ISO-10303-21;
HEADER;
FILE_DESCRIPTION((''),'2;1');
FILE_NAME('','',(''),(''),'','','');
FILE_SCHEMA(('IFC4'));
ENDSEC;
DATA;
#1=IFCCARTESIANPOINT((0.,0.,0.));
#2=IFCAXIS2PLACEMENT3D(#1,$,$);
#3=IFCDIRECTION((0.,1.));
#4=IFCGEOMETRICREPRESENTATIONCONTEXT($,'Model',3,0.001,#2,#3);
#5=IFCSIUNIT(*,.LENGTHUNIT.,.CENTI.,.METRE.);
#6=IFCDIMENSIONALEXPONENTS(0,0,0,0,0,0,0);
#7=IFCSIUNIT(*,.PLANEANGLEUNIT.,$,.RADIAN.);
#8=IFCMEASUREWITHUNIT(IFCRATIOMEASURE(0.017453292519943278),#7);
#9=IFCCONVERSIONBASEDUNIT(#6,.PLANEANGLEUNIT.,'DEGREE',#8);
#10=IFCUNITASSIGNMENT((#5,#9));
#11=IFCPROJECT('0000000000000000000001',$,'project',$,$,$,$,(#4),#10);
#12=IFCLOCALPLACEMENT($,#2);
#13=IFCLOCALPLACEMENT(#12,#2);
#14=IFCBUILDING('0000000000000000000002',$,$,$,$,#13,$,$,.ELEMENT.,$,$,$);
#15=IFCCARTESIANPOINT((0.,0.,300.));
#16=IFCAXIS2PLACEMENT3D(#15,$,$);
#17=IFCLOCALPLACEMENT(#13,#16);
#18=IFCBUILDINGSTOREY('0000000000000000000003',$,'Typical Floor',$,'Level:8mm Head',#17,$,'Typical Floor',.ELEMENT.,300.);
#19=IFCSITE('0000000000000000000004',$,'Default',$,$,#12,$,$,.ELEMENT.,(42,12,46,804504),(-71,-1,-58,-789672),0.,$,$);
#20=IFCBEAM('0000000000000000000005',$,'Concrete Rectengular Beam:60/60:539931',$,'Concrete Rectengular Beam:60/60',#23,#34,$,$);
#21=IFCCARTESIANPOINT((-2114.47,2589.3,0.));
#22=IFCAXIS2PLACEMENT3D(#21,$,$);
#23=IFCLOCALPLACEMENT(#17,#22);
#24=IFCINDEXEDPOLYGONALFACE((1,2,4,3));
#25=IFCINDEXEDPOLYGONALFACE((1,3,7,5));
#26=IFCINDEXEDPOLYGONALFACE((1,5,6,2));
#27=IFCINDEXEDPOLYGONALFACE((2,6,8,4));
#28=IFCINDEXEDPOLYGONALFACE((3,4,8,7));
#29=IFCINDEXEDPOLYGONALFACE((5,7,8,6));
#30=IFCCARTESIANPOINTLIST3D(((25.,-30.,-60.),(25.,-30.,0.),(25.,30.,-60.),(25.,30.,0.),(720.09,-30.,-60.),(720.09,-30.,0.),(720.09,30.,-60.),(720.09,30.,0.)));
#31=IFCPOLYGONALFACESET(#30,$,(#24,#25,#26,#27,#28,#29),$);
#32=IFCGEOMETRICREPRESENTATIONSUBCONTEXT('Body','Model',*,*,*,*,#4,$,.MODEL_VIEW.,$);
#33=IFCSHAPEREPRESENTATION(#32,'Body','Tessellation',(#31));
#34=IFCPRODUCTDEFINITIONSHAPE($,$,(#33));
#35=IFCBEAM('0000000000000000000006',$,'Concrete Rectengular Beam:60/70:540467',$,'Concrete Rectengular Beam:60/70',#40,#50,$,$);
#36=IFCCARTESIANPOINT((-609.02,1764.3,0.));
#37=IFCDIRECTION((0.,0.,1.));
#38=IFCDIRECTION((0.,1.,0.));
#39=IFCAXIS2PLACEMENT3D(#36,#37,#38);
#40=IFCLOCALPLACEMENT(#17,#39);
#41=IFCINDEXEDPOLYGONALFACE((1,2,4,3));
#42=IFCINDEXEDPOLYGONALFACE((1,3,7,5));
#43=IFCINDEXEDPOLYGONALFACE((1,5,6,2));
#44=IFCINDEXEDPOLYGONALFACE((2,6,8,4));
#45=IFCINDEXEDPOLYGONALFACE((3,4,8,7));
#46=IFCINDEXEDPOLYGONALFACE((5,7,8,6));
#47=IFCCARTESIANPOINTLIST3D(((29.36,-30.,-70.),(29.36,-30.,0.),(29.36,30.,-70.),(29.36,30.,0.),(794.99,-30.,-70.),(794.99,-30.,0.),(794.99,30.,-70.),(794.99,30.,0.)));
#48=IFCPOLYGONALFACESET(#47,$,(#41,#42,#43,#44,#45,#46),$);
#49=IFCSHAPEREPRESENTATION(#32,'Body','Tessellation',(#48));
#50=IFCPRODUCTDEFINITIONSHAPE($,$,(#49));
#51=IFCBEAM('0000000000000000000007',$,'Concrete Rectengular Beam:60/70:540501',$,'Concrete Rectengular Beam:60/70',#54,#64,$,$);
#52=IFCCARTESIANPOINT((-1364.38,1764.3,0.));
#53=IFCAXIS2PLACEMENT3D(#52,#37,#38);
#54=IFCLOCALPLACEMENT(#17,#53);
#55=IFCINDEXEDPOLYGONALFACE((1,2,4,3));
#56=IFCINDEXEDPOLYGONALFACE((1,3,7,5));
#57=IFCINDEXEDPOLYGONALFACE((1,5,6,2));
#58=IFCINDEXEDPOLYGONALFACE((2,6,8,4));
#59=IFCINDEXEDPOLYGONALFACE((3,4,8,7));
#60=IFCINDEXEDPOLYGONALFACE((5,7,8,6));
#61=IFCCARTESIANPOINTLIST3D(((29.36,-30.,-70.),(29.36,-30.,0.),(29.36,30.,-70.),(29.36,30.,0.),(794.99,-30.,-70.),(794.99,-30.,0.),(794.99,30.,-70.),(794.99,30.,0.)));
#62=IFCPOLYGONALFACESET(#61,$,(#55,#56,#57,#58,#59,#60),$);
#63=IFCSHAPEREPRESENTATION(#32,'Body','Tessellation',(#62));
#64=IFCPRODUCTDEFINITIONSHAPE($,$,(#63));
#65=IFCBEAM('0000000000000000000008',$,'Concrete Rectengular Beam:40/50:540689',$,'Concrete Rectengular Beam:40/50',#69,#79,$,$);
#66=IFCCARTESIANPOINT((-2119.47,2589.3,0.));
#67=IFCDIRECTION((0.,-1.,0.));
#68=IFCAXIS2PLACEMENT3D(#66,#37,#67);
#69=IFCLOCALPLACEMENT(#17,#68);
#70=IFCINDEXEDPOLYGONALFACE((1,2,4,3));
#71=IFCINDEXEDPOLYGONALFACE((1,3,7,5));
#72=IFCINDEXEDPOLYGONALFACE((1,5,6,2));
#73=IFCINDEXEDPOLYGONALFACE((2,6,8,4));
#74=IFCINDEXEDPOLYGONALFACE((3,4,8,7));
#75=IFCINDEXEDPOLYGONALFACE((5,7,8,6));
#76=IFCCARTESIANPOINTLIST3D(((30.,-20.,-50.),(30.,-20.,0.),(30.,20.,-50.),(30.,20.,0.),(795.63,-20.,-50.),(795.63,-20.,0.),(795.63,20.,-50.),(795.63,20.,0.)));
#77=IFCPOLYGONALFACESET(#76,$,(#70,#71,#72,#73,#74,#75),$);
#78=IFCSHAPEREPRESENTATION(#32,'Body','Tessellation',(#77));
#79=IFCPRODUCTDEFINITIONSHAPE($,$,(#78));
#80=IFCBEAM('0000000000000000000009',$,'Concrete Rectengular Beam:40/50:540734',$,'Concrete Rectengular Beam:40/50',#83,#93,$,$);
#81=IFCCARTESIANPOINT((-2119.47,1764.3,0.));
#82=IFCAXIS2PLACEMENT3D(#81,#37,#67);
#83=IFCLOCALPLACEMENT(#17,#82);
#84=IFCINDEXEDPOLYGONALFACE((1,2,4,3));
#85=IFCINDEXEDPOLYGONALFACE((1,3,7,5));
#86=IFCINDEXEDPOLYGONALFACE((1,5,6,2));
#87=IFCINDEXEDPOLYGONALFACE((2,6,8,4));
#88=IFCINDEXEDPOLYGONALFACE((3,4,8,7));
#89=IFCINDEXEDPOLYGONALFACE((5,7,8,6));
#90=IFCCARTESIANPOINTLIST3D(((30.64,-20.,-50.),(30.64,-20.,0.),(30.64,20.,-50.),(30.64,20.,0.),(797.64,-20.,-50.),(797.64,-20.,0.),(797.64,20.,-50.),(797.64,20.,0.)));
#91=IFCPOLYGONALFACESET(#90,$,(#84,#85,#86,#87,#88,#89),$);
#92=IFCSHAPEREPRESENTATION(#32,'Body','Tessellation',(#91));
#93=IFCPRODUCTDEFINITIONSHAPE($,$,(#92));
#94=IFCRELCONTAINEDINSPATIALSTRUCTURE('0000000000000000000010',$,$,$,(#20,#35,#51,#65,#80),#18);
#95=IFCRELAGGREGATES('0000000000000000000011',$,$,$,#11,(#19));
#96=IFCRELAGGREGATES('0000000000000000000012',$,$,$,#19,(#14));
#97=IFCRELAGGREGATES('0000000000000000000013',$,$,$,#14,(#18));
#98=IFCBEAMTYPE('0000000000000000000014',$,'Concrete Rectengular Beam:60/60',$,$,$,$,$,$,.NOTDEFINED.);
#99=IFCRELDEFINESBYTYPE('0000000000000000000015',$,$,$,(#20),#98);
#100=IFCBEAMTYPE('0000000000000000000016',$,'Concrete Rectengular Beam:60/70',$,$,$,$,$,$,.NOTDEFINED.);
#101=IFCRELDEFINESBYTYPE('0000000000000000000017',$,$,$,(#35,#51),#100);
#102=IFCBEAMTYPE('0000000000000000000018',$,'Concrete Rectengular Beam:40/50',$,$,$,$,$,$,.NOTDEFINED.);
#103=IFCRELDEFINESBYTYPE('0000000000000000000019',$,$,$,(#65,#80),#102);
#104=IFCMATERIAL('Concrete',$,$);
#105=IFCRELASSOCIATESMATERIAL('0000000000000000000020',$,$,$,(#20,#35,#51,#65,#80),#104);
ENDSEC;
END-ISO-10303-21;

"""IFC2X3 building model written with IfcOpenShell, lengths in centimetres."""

from ifc_helpers import new_model, entity, si_unit, converted_unit, direction, frame, frame_2d, origin, origin_2d_with_axis, place, context, subcontext, project, spatial, rectangle, extrude, material, type_object, element, save


model = new_model("IFC2X3")

# Units and contexts
model_context = context("Model", 3, precision=0.001, world=origin(), true_north=direction((0.0, 1.0)))
body_context = subcontext(model_context, "Body", "Model", "MODEL_VIEW")
ifc_project = project(units=[si_unit("LENGTHUNIT", "METRE", prefix="CENTI"), converted_unit("PLANEANGLEUNIT", "DEGREE", entity("IfcRatioMeasure", 0.017453292519943278), si_unit("PLANEANGLEUNIT", "RADIAN"), dimensions=[0, 0, 0, 0, 0, 0, 0])], contexts=[model_context])

# Site, building, storey
site_placement = place(None, origin())
site = spatial("IfcSite", under=ifc_project, at=site_placement, Name="Default", CompositionType="ELEMENT", RefLatitude=(42, 12, 46, 804504), RefLongitude=(-71, -1, -58, -789672), RefElevation=0.0)
building_placement = place(site_placement, origin())
building = spatial("IfcBuilding", under=site, at=building_placement, CompositionType="ELEMENT")
storey_placement = place(building_placement, frame((0.0, 0.0, 300.0)))
storey = spatial("IfcBuildingStorey", under=building, at=storey_placement, Name="Typical Floor", ObjectType="Level:8mm Head", LongName="Typical Floor", CompositionType="ELEMENT", Elevation=300.0)

# Beams
ifc_material = material(Name="Concrete")
beam_type_1 = type_object("IfcBeamType", Name="Concrete Rectengular Beam:60/60", PredefinedType="NOTDEFINED")
beam_1_placement = place(storey_placement, frame((-2114.47, 2589.3, 0.0)))
element("IfcBeam", 1, at=beam_1_placement, inside=storey, type_object=beam_type_1, material=ifc_material, Name="Concrete Rectengular Beam:60/60:539931", ObjectType="Concrete Rectengular Beam:60/60", context=body_context, shape_type="SweptSolid", body=[
    extrude(rectangle(XDim=60.0, YDim=60.0, at=frame_2d((0.0, 0.0), x_axis=(1.0, 0.0))), frame((25.0, 0.0, -30.0), z_axis=(1.0, 0.0, 0.0), x_axis=(0.0, 0.0, -1.0)), (0.0, 0.0, 1.0), 695.09),
])
beam_type_2 = type_object("IfcBeamType", Name="Concrete Rectengular Beam:60/70", PredefinedType="NOTDEFINED")
beam_2_placement = place(storey_placement, frame((-609.02, 1764.3, 0.0), z_axis=(0.0, 0.0, 1.0), x_axis=(0.0, 1.0, 0.0)))
element("IfcBeam", 2, at=beam_2_placement, inside=storey, type_object=beam_type_2, material=ifc_material, Name="Concrete Rectengular Beam:60/70:540467", ObjectType="Concrete Rectengular Beam:60/70", context=body_context, shape_type="SweptSolid", body=[
    extrude(rectangle(XDim=70.0, YDim=60.0, at=origin_2d_with_axis()), frame((29.36, 0.0, -35.0), z_axis=(1.0, 0.0, 0.0), x_axis=(0.0, 0.0, -1.0)), (0.0, 0.0, 1.0), 765.63),
])
beam_3_placement = place(storey_placement, frame((-1364.38, 1764.3, 0.0), z_axis=(0.0, 0.0, 1.0), x_axis=(0.0, 1.0, 0.0)))
element("IfcBeam", 3, at=beam_3_placement, inside=storey, type_object=beam_type_2, material=ifc_material, Name="Concrete Rectengular Beam:60/70:540501", ObjectType="Concrete Rectengular Beam:60/70", context=body_context, shape_type="SweptSolid", body=[
    extrude(rectangle(XDim=70.0, YDim=60.0, at=frame_2d((0.0, 0.0), x_axis=(1.0, 0.0))), frame((29.36, 0.0, -35.0), z_axis=(1.0, 0.0, 0.0), x_axis=(0.0, 0.0, -1.0)), (0.0, 0.0, 1.0), 765.63),
])
beam_type_3 = type_object("IfcBeamType", Name="Concrete Rectengular Beam:40/50", PredefinedType="NOTDEFINED")
beam_4_placement = place(storey_placement, frame((-2119.47, 2589.3, 0.0), z_axis=(0.0, 0.0, 1.0), x_axis=(0.0, -1.0, 0.0)))
element("IfcBeam", 4, at=beam_4_placement, inside=storey, type_object=beam_type_3, material=ifc_material, Name="Concrete Rectengular Beam:40/50:540689", ObjectType="Concrete Rectengular Beam:40/50", context=body_context, shape_type="SweptSolid", body=[
    extrude(rectangle(XDim=50.0, YDim=40.0, at=origin_2d_with_axis()), frame((30.0, 0.0, -25.0), z_axis=(1.0, 0.0, 0.0), x_axis=(0.0, 0.0, -1.0)), (0.0, 0.0, 1.0), 765.63),
])
beam_5_placement = place(storey_placement, frame((-2119.47, 1764.3, 0.0), z_axis=(0.0, 0.0, 1.0), x_axis=(0.0, -1.0, 0.0)))
element("IfcBeam", 5, at=beam_5_placement, inside=storey, type_object=beam_type_3, material=ifc_material, Name="Concrete Rectengular Beam:40/50:540734", ObjectType="Concrete Rectengular Beam:40/50", context=body_context, shape_type="SweptSolid", body=[
    extrude(rectangle(XDim=50.0, YDim=40.0, at=origin_2d_with_axis()), frame((30.64, 0.0, -25.0), z_axis=(1.0, 0.0, 0.0), x_axis=(0.0, 0.0, -1.0)), (0.0, 0.0, 1.0), 767.0),
])

save(model, "model.ifc")
